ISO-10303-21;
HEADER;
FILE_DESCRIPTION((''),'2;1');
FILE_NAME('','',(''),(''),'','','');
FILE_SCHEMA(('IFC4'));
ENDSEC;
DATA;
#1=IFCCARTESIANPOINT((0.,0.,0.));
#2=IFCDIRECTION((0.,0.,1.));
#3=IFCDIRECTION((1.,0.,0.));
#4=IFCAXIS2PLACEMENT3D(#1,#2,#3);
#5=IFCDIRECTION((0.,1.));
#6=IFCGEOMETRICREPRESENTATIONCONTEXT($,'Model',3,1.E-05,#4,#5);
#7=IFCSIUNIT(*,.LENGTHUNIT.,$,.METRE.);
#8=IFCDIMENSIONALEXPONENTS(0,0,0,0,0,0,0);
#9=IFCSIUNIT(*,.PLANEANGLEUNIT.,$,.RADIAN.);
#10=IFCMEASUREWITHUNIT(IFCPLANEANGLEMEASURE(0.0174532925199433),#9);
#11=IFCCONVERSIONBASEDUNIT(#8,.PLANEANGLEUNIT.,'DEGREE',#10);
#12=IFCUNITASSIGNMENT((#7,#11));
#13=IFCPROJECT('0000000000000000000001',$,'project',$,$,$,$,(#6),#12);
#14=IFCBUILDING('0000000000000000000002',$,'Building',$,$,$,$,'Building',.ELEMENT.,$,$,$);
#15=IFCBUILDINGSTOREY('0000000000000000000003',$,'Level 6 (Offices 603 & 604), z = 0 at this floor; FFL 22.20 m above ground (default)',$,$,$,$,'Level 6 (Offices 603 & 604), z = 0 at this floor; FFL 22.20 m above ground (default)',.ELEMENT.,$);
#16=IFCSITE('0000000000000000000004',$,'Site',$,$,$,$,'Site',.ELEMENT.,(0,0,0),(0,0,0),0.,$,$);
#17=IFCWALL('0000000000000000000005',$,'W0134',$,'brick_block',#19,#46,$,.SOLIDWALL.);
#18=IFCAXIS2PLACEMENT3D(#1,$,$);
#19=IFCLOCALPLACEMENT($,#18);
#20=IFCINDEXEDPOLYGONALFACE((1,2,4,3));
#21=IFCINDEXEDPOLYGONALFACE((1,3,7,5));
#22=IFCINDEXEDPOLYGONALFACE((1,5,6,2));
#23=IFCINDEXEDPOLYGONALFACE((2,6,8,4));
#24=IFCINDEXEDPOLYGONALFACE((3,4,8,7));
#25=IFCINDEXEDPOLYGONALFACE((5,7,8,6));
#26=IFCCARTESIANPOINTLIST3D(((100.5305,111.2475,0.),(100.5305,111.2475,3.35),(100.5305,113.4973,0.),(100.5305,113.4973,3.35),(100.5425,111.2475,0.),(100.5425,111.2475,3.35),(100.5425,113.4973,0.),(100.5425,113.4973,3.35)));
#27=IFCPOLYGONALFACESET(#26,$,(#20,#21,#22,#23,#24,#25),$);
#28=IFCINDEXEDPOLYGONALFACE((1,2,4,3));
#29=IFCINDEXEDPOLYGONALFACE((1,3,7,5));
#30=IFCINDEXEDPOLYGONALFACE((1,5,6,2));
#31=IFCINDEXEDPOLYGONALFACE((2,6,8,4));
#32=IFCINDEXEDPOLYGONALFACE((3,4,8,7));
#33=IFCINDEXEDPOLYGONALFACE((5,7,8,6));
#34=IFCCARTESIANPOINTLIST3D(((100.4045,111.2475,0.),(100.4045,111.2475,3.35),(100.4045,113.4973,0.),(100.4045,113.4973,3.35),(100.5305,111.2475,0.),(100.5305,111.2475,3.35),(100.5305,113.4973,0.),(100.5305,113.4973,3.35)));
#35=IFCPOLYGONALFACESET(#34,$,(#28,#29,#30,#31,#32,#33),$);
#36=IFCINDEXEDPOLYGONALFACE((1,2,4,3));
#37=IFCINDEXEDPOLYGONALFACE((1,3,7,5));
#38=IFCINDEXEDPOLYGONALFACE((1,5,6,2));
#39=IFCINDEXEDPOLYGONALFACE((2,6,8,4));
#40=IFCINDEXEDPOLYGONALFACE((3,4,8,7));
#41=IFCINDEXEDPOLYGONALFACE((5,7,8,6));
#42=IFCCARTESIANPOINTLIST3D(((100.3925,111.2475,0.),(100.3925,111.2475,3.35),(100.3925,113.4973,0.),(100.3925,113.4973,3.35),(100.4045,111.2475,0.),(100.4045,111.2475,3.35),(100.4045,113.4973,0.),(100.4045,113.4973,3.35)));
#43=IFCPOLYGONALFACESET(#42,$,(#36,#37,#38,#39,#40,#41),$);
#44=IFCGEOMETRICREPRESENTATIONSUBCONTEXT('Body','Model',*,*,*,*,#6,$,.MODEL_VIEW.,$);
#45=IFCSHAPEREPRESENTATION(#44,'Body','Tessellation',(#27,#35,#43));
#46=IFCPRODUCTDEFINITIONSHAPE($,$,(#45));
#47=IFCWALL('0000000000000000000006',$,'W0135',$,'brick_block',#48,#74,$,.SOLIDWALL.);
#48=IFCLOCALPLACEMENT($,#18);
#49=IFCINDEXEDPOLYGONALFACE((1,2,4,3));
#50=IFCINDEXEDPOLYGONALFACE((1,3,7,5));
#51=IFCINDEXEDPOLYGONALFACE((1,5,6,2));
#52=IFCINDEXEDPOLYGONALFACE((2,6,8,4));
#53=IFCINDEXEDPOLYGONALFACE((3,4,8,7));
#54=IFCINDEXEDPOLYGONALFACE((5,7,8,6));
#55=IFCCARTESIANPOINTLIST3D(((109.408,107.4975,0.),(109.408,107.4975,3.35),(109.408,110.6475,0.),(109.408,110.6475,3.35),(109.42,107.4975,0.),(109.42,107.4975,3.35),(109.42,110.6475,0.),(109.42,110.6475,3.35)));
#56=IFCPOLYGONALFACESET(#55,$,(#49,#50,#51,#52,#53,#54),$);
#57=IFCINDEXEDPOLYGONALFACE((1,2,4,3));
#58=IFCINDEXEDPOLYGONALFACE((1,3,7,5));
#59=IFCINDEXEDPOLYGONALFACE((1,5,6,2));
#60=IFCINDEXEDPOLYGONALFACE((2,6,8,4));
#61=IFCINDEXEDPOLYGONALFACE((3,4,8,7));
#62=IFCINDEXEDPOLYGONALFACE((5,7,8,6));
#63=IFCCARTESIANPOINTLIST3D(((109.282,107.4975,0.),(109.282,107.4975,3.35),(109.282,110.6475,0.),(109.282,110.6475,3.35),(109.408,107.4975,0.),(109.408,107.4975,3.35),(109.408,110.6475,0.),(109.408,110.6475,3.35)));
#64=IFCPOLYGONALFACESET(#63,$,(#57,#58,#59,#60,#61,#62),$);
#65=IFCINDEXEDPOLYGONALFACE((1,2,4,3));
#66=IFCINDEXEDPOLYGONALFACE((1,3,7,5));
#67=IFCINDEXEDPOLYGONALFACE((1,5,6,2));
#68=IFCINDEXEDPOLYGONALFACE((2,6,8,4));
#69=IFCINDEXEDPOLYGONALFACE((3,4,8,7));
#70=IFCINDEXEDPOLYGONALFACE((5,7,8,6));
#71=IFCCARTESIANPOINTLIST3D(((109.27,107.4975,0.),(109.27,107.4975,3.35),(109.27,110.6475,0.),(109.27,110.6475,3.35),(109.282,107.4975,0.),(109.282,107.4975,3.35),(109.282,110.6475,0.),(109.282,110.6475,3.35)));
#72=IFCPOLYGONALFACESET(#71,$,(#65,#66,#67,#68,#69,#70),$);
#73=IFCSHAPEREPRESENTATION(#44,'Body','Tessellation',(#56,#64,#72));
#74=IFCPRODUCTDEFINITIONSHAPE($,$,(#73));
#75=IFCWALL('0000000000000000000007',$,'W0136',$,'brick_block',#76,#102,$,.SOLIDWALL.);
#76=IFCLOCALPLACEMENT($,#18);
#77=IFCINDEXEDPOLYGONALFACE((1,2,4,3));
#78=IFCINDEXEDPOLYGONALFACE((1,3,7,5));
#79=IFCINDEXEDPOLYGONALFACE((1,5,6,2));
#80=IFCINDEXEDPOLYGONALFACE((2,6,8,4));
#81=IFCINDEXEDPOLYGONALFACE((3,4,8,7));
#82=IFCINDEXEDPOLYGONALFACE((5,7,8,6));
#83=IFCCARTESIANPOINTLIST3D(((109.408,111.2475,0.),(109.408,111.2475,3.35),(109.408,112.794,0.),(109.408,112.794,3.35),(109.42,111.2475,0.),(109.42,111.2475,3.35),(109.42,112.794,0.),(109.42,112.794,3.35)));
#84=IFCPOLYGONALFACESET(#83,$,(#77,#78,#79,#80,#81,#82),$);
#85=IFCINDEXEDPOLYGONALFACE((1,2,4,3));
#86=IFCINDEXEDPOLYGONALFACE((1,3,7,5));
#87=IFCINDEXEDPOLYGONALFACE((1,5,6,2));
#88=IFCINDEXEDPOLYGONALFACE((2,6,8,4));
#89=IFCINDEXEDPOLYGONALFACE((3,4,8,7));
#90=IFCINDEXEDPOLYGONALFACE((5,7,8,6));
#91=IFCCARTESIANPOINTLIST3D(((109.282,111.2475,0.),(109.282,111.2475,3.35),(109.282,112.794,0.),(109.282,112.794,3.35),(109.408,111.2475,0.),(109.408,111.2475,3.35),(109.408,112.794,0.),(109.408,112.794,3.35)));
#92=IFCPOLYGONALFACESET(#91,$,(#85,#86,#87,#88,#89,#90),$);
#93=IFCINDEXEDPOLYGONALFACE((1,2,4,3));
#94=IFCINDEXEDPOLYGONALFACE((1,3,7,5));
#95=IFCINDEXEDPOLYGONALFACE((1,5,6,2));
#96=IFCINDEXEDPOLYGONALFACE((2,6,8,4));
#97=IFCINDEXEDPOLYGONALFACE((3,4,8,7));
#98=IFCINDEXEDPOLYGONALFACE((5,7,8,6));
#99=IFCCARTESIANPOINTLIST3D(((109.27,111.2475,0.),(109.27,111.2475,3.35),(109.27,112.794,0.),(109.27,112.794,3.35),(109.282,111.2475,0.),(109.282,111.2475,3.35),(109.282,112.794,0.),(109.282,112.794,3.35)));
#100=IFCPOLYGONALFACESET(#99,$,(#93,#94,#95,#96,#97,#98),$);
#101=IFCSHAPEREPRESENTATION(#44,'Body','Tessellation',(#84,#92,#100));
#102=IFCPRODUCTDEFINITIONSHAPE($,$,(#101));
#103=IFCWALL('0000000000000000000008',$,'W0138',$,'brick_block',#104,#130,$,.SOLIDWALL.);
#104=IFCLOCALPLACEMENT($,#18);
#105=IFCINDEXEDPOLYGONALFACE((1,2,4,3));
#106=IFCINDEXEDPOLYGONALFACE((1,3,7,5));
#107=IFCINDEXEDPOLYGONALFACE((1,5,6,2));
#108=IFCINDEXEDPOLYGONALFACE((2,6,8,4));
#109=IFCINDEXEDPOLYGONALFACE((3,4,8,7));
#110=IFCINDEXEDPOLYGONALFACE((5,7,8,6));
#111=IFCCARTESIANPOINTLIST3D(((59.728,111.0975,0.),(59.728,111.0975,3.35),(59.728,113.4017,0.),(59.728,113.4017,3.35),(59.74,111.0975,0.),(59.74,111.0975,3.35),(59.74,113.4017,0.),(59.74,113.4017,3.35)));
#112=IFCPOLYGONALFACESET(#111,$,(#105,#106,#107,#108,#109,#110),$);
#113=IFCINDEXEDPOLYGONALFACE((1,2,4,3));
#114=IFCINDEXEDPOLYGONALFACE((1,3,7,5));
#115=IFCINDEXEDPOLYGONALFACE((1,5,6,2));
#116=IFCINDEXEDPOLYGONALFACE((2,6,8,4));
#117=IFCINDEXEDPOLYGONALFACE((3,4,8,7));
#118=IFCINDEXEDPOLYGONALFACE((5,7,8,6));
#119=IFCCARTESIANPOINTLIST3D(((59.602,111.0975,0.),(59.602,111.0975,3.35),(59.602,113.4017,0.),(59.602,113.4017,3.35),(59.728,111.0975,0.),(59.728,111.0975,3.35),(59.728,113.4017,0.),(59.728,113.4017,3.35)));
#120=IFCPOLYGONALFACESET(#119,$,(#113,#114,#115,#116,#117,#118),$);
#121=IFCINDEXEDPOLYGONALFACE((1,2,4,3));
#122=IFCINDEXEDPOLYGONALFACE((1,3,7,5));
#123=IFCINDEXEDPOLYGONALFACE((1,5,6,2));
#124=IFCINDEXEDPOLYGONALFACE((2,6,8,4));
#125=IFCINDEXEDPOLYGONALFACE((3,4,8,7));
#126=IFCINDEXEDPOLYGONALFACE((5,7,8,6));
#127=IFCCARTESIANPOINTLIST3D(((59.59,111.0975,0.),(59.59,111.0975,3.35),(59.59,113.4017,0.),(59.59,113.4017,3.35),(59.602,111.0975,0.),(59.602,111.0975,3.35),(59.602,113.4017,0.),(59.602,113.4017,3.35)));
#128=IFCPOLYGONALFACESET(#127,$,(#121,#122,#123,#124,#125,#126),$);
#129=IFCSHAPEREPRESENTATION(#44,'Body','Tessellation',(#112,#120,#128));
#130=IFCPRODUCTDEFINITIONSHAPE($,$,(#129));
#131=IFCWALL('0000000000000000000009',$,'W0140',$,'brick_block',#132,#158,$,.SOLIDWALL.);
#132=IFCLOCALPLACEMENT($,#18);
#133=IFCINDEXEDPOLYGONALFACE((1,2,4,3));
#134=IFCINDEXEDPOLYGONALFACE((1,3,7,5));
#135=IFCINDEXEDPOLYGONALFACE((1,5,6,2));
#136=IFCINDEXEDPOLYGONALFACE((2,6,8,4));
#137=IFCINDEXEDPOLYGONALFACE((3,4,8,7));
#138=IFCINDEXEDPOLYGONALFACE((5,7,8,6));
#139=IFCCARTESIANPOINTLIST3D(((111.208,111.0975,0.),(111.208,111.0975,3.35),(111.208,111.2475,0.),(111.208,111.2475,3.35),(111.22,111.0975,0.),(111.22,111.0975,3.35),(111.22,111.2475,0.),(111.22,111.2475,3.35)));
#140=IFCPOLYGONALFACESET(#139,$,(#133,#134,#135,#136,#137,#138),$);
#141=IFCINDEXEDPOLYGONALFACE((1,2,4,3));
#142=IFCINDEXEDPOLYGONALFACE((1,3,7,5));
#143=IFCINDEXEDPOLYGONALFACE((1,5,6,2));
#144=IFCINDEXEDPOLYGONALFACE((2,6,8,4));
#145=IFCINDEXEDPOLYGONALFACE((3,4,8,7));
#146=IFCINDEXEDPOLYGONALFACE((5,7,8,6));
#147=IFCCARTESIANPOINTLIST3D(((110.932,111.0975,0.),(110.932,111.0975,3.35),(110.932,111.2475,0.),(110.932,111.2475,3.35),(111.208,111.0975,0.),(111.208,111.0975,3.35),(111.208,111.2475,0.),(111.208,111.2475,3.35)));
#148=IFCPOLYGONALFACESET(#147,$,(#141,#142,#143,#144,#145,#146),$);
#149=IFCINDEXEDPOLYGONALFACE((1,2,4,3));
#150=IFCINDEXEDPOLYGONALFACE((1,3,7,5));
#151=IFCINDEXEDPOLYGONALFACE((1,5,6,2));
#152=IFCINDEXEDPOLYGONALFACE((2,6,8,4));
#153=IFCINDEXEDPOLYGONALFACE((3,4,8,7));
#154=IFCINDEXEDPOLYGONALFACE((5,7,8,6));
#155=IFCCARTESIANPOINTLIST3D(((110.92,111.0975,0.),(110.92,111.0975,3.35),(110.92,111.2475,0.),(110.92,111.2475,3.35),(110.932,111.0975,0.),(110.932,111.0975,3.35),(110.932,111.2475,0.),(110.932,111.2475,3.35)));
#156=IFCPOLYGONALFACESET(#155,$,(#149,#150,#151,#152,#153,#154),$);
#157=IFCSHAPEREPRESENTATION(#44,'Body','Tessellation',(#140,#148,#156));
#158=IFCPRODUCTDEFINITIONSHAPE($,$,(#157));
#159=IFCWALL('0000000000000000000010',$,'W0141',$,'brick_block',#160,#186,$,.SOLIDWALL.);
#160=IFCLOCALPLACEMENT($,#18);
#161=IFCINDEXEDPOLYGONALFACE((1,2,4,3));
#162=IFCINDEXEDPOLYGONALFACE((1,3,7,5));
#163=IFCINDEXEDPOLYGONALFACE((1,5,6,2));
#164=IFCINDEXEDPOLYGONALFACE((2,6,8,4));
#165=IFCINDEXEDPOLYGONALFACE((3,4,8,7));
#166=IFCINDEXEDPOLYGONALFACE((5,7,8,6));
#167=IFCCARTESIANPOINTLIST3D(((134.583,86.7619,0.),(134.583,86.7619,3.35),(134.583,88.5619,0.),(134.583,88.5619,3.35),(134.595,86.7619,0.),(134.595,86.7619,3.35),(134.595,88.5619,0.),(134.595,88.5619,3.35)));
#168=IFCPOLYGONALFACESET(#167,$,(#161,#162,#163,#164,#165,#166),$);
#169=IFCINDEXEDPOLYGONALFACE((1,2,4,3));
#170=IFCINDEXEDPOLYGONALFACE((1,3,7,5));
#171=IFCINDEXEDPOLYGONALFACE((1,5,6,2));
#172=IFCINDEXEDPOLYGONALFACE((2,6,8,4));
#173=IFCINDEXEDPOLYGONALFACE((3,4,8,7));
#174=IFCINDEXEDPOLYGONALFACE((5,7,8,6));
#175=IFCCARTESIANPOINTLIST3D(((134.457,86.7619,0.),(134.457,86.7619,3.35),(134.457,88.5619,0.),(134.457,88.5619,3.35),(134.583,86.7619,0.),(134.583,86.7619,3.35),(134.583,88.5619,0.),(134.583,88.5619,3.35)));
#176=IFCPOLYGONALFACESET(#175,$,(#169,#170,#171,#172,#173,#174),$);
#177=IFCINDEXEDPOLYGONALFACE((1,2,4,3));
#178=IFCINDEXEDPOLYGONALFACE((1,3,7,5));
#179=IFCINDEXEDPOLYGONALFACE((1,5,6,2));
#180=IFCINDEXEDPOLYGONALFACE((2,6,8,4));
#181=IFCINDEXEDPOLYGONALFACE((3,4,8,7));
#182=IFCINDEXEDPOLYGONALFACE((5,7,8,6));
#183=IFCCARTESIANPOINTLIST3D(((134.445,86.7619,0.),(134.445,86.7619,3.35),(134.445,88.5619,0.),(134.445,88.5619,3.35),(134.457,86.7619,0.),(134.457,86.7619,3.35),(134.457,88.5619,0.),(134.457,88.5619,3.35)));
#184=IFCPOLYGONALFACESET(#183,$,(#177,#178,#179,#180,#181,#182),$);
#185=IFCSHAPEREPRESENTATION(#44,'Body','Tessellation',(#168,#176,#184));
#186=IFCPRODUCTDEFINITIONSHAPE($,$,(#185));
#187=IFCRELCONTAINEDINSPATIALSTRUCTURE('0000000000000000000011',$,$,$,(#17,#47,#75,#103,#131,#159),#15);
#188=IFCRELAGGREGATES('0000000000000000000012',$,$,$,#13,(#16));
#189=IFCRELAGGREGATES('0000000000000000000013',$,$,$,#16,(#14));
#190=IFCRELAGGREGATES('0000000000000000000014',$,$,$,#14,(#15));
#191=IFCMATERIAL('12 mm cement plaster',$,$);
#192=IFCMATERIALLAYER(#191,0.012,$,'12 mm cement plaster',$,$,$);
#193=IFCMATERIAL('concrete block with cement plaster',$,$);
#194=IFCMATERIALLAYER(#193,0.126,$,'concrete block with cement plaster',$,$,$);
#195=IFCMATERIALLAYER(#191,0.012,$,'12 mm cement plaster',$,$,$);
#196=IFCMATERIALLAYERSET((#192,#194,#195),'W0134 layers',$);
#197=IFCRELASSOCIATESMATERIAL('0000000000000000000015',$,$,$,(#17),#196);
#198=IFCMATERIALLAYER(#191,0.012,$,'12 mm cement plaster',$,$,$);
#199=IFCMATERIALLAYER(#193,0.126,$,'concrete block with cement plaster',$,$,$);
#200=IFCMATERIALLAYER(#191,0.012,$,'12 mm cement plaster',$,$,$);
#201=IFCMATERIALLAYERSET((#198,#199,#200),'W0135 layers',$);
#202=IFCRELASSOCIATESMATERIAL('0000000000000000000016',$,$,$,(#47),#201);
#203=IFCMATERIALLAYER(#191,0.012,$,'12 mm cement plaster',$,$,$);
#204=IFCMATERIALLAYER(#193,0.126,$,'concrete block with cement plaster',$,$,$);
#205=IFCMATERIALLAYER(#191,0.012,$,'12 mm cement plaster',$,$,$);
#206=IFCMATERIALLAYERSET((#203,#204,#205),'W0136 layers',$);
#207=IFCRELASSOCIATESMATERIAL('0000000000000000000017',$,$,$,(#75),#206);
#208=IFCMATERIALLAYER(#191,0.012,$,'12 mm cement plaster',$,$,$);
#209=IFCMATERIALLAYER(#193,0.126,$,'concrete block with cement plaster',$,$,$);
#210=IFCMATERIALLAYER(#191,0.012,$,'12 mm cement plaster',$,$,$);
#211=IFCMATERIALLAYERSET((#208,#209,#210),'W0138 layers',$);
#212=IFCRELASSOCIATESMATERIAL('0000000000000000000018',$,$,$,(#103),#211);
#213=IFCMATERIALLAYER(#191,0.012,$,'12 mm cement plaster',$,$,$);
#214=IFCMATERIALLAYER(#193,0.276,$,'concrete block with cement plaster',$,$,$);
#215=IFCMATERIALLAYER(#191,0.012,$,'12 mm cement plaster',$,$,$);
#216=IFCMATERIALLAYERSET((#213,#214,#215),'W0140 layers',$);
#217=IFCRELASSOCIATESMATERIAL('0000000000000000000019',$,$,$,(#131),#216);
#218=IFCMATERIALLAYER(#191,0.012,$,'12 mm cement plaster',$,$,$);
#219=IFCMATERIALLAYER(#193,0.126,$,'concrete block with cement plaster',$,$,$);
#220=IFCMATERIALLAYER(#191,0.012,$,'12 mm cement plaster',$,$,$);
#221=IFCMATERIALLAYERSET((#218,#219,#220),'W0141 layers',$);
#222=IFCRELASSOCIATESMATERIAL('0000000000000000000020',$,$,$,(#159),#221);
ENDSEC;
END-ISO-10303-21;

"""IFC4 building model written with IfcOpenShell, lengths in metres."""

from ifc_helpers import new_model, entity, si_unit, converted_unit, direction, frame, frame_2d, origin_with_axes, place, context, subcontext, project, spatial, rectangle, extrude, material, layer, layer_set, layer_usage, element, save


model = new_model("IFC4")

# Units and contexts
model_context = context("Model", 3, precision=1e-05, world=origin_with_axes(), true_north=direction((0.0, 1.0)))
body_context = subcontext(model_context, "Body", "Model", "MODEL_VIEW")
ifc_project = project(units=[si_unit("LENGTHUNIT", "METRE"), converted_unit("PLANEANGLEUNIT", "DEGREE", entity("IfcPlaneAngleMeasure", 0.0174532925199433), si_unit("PLANEANGLEUNIT", "RADIAN"), dimensions=[0, 0, 0, 0, 0, 0, 0])], contexts=[model_context])

# Site, building, storey
site = spatial("IfcSite", under=ifc_project, Name="Site", LongName="Site", CompositionType="ELEMENT", RefLatitude=(0, 0, 0), RefLongitude=(0, 0, 0), RefElevation=0.0)
building = spatial("IfcBuilding", under=site, Name="Building", LongName="Building", CompositionType="ELEMENT")
storey = spatial("IfcBuildingStorey", under=building, Name="Level 6 (Offices 603 & 604), z = 0 at this floor; FFL 22.20 m above ground (default)", LongName="Level 6 (Offices 603 & 604), z = 0 at this floor; FFL 22.20 m above ground (default)", CompositionType="ELEMENT")

# Walls
ifc_material_1 = material(Name="12 mm cement plaster")
ifc_material_2 = material(Name="concrete block with cement plaster")
placement = place(None, origin_with_axes())
ifc_layer_1 = layer(ifc_material_1, 0.012, Name="12 mm cement plaster")
ifc_layer_2 = layer(ifc_material_2, 0.126, Name="concrete block with cement plaster")
ifc_layer_3 = layer(ifc_material_1, 0.012, Name="12 mm cement plaster")
ifc_layer_set_1 = layer_set([ifc_layer_1, ifc_layer_2, ifc_layer_3], Name="W0134 layers")
ifc_layer_usage_1 = layer_usage(ifc_layer_set_1, "AXIS2", "POSITIVE", -0.075)
element("IfcWall", 1, at=placement, inside=storey, material=ifc_layer_usage_1, Name="W0134", ObjectType="brick_block", PredefinedType="SOLIDWALL", context=body_context, shape_type="SweptSolid", body=[
    extrude(rectangle(XDim=2.2498, YDim=0.012, at=frame_2d((0.0, 0.0), x_axis=(0.0, 1.0))), frame((100.5365, 112.3724, 0.0), z_axis=(0.0, 0.0, 1.0), x_axis=(1.0, 0.0, 0.0)), (0.0, 0.0, 1.0), 3.35),
    extrude(rectangle(XDim=2.2498, YDim=0.126, at=frame_2d((-0.069, 0.0), x_axis=(0.0, 1.0))), frame((100.5365, 112.3724, 0.0), z_axis=(0.0, 0.0, 1.0), x_axis=(1.0, 0.0, 0.0)), (0.0, 0.0, 1.0), 3.35),
    extrude(rectangle(XDim=2.2498, YDim=0.012, at=frame_2d((-0.138, 0.0), x_axis=(0.0, 1.0))), frame((100.5365, 112.3724, 0.0), z_axis=(0.0, 0.0, 1.0), x_axis=(1.0, 0.0, 0.0)), (0.0, 0.0, 1.0), 3.35),
])
ifc_layer_4 = layer(ifc_material_1, 0.012, Name="12 mm cement plaster")
ifc_layer_5 = layer(ifc_material_2, 0.126, Name="concrete block with cement plaster")
ifc_layer_6 = layer(ifc_material_1, 0.012, Name="12 mm cement plaster")
ifc_layer_set_2 = layer_set([ifc_layer_4, ifc_layer_5, ifc_layer_6], Name="W0135 layers")
ifc_layer_usage_2 = layer_usage(ifc_layer_set_2, "AXIS2", "POSITIVE", -0.075)
element("IfcWall", 2, at=placement, inside=storey, material=ifc_layer_usage_2, Name="W0135", ObjectType="brick_block", PredefinedType="SOLIDWALL", context=body_context, shape_type="SweptSolid", body=[
    extrude(rectangle(XDim=3.15, YDim=0.012, at=frame_2d((0.0, 0.0), x_axis=(0.0, 1.0))), frame((109.414, 109.0725, 0.0), z_axis=(0.0, 0.0, 1.0), x_axis=(1.0, 0.0, 0.0)), (0.0, 0.0, 1.0), 3.35),
    extrude(rectangle(XDim=3.15, YDim=0.126, at=frame_2d((-0.069, 0.0), x_axis=(0.0, 1.0))), frame((109.414, 109.0725, 0.0), z_axis=(0.0, 0.0, 1.0), x_axis=(1.0, 0.0, 0.0)), (0.0, 0.0, 1.0), 3.35),
    extrude(rectangle(XDim=3.15, YDim=0.012, at=frame_2d((-0.138, 0.0), x_axis=(0.0, 1.0))), frame((109.414, 109.0725, 0.0), z_axis=(0.0, 0.0, 1.0), x_axis=(1.0, 0.0, 0.0)), (0.0, 0.0, 1.0), 3.35),
])
ifc_layer_7 = layer(ifc_material_1, 0.012, Name="12 mm cement plaster")
ifc_layer_8 = layer(ifc_material_2, 0.126, Name="concrete block with cement plaster")
ifc_layer_9 = layer(ifc_material_1, 0.012, Name="12 mm cement plaster")
ifc_layer_set_3 = layer_set([ifc_layer_7, ifc_layer_8, ifc_layer_9], Name="W0136 layers")
ifc_layer_usage_3 = layer_usage(ifc_layer_set_3, "AXIS2", "POSITIVE", -0.075)
element("IfcWall", 3, at=placement, inside=storey, material=ifc_layer_usage_3, Name="W0136", ObjectType="brick_block", PredefinedType="SOLIDWALL", context=body_context, shape_type="SweptSolid", body=[
    extrude(rectangle(XDim=1.5465, YDim=0.012, at=frame_2d((0.0, 0.0), x_axis=(0.0, 1.0))), frame((109.414, 112.0208, 0.0), z_axis=(0.0, 0.0, 1.0), x_axis=(1.0, 0.0, 0.0)), (0.0, 0.0, 1.0), 3.35),
    extrude(rectangle(XDim=1.5465, YDim=0.126, at=frame_2d((-0.069, 0.0), x_axis=(0.0, 1.0))), frame((109.414, 112.0208, 0.0), z_axis=(0.0, 0.0, 1.0), x_axis=(1.0, 0.0, 0.0)), (0.0, 0.0, 1.0), 3.35),
    extrude(rectangle(XDim=1.5465, YDim=0.012, at=frame_2d((-0.138, 0.0), x_axis=(0.0, 1.0))), frame((109.414, 112.0208, 0.0), z_axis=(0.0, 0.0, 1.0), x_axis=(1.0, 0.0, 0.0)), (0.0, 0.0, 1.0), 3.35),
])
ifc_layer_10 = layer(ifc_material_1, 0.012, Name="12 mm cement plaster")
ifc_layer_11 = layer(ifc_material_2, 0.126, Name="concrete block with cement plaster")
ifc_layer_12 = layer(ifc_material_1, 0.012, Name="12 mm cement plaster")
ifc_layer_set_4 = layer_set([ifc_layer_10, ifc_layer_11, ifc_layer_12], Name="W0138 layers")
ifc_layer_usage_4 = layer_usage(ifc_layer_set_4, "AXIS2", "POSITIVE", -0.075)
element("IfcWall", 4, at=placement, inside=storey, material=ifc_layer_usage_4, Name="W0138", ObjectType="brick_block", PredefinedType="SOLIDWALL", context=body_context, shape_type="SweptSolid", body=[
    extrude(rectangle(XDim=2.3042, YDim=0.012, at=frame_2d((0.0, 0.0), x_axis=(0.0, 1.0))), frame((59.734, 112.2496, 0.0), z_axis=(0.0, 0.0, 1.0), x_axis=(1.0, 0.0, 0.0)), (0.0, 0.0, 1.0), 3.35),
    extrude(rectangle(XDim=2.3042, YDim=0.126, at=frame_2d((-0.069, 0.0), x_axis=(0.0, 1.0))), frame((59.734, 112.2496, 0.0), z_axis=(0.0, 0.0, 1.0), x_axis=(1.0, 0.0, 0.0)), (0.0, 0.0, 1.0), 3.35),
    extrude(rectangle(XDim=2.3042, YDim=0.012, at=frame_2d((-0.138, 0.0), x_axis=(0.0, 1.0))), frame((59.734, 112.2496, 0.0), z_axis=(0.0, 0.0, 1.0), x_axis=(1.0, 0.0, 0.0)), (0.0, 0.0, 1.0), 3.35),
])
ifc_layer_13 = layer(ifc_material_1, 0.012, Name="12 mm cement plaster")
ifc_layer_14 = layer(ifc_material_2, 0.276, Name="concrete block with cement plaster")
ifc_layer_15 = layer(ifc_material_1, 0.012, Name="12 mm cement plaster")
ifc_layer_set_5 = layer_set([ifc_layer_13, ifc_layer_14, ifc_layer_15], Name="W0140 layers")
ifc_layer_usage_5 = layer_usage(ifc_layer_set_5, "AXIS2", "POSITIVE", -0.15)
element("IfcWall", 5, at=placement, inside=storey, material=ifc_layer_usage_5, Name="W0140", ObjectType="brick_block", PredefinedType="SOLIDWALL", context=body_context, shape_type="SweptSolid", body=[
    extrude(rectangle(XDim=0.15, YDim=0.012, at=frame_2d((0.0, 0.0), x_axis=(0.0, 1.0))), frame((111.214, 111.1725, 0.0), z_axis=(0.0, 0.0, 1.0), x_axis=(1.0, 0.0, 0.0)), (0.0, 0.0, 1.0), 3.35),
    extrude(rectangle(XDim=0.15, YDim=0.276, at=frame_2d((-0.144, 0.0), x_axis=(0.0, 1.0))), frame((111.214, 111.1725, 0.0), z_axis=(0.0, 0.0, 1.0), x_axis=(1.0, 0.0, 0.0)), (0.0, 0.0, 1.0), 3.35),
    extrude(rectangle(XDim=0.15, YDim=0.012, at=frame_2d((-0.288, 0.0), x_axis=(0.0, 1.0))), frame((111.214, 111.1725, 0.0), z_axis=(0.0, 0.0, 1.0), x_axis=(1.0, 0.0, 0.0)), (0.0, 0.0, 1.0), 3.35),
])
ifc_layer_16 = layer(ifc_material_1, 0.012, Name="12 mm cement plaster")
ifc_layer_17 = layer(ifc_material_2, 0.126, Name="concrete block with cement plaster")
ifc_layer_18 = layer(ifc_material_1, 0.012, Name="12 mm cement plaster")
ifc_layer_set_6 = layer_set([ifc_layer_16, ifc_layer_17, ifc_layer_18], Name="W0141 layers")
ifc_layer_usage_6 = layer_usage(ifc_layer_set_6, "AXIS2", "POSITIVE", -0.075)
element("IfcWall", 6, at=placement, inside=storey, material=ifc_layer_usage_6, Name="W0141", ObjectType="brick_block", PredefinedType="SOLIDWALL", context=body_context, shape_type="SweptSolid", body=[
    extrude(rectangle(XDim=1.8, YDim=0.012, at=frame_2d((0.0, 0.0), x_axis=(0.0, 1.0))), frame((134.589, 87.6619, 0.0), z_axis=(0.0, 0.0, 1.0), x_axis=(1.0, 0.0, 0.0)), (0.0, 0.0, 1.0), 3.35),
    extrude(rectangle(XDim=1.8, YDim=0.126, at=frame_2d((-0.069, 0.0), x_axis=(0.0, 1.0))), frame((134.589, 87.6619, 0.0), z_axis=(0.0, 0.0, 1.0), x_axis=(1.0, 0.0, 0.0)), (0.0, 0.0, 1.0), 3.35),
    extrude(rectangle(XDim=1.8, YDim=0.012, at=frame_2d((-0.138, 0.0), x_axis=(0.0, 1.0))), frame((134.589, 87.6619, 0.0), z_axis=(0.0, 0.0, 1.0), x_axis=(1.0, 0.0, 0.0)), (0.0, 0.0, 1.0), 3.35),
])

save(model, "model.ifc")
